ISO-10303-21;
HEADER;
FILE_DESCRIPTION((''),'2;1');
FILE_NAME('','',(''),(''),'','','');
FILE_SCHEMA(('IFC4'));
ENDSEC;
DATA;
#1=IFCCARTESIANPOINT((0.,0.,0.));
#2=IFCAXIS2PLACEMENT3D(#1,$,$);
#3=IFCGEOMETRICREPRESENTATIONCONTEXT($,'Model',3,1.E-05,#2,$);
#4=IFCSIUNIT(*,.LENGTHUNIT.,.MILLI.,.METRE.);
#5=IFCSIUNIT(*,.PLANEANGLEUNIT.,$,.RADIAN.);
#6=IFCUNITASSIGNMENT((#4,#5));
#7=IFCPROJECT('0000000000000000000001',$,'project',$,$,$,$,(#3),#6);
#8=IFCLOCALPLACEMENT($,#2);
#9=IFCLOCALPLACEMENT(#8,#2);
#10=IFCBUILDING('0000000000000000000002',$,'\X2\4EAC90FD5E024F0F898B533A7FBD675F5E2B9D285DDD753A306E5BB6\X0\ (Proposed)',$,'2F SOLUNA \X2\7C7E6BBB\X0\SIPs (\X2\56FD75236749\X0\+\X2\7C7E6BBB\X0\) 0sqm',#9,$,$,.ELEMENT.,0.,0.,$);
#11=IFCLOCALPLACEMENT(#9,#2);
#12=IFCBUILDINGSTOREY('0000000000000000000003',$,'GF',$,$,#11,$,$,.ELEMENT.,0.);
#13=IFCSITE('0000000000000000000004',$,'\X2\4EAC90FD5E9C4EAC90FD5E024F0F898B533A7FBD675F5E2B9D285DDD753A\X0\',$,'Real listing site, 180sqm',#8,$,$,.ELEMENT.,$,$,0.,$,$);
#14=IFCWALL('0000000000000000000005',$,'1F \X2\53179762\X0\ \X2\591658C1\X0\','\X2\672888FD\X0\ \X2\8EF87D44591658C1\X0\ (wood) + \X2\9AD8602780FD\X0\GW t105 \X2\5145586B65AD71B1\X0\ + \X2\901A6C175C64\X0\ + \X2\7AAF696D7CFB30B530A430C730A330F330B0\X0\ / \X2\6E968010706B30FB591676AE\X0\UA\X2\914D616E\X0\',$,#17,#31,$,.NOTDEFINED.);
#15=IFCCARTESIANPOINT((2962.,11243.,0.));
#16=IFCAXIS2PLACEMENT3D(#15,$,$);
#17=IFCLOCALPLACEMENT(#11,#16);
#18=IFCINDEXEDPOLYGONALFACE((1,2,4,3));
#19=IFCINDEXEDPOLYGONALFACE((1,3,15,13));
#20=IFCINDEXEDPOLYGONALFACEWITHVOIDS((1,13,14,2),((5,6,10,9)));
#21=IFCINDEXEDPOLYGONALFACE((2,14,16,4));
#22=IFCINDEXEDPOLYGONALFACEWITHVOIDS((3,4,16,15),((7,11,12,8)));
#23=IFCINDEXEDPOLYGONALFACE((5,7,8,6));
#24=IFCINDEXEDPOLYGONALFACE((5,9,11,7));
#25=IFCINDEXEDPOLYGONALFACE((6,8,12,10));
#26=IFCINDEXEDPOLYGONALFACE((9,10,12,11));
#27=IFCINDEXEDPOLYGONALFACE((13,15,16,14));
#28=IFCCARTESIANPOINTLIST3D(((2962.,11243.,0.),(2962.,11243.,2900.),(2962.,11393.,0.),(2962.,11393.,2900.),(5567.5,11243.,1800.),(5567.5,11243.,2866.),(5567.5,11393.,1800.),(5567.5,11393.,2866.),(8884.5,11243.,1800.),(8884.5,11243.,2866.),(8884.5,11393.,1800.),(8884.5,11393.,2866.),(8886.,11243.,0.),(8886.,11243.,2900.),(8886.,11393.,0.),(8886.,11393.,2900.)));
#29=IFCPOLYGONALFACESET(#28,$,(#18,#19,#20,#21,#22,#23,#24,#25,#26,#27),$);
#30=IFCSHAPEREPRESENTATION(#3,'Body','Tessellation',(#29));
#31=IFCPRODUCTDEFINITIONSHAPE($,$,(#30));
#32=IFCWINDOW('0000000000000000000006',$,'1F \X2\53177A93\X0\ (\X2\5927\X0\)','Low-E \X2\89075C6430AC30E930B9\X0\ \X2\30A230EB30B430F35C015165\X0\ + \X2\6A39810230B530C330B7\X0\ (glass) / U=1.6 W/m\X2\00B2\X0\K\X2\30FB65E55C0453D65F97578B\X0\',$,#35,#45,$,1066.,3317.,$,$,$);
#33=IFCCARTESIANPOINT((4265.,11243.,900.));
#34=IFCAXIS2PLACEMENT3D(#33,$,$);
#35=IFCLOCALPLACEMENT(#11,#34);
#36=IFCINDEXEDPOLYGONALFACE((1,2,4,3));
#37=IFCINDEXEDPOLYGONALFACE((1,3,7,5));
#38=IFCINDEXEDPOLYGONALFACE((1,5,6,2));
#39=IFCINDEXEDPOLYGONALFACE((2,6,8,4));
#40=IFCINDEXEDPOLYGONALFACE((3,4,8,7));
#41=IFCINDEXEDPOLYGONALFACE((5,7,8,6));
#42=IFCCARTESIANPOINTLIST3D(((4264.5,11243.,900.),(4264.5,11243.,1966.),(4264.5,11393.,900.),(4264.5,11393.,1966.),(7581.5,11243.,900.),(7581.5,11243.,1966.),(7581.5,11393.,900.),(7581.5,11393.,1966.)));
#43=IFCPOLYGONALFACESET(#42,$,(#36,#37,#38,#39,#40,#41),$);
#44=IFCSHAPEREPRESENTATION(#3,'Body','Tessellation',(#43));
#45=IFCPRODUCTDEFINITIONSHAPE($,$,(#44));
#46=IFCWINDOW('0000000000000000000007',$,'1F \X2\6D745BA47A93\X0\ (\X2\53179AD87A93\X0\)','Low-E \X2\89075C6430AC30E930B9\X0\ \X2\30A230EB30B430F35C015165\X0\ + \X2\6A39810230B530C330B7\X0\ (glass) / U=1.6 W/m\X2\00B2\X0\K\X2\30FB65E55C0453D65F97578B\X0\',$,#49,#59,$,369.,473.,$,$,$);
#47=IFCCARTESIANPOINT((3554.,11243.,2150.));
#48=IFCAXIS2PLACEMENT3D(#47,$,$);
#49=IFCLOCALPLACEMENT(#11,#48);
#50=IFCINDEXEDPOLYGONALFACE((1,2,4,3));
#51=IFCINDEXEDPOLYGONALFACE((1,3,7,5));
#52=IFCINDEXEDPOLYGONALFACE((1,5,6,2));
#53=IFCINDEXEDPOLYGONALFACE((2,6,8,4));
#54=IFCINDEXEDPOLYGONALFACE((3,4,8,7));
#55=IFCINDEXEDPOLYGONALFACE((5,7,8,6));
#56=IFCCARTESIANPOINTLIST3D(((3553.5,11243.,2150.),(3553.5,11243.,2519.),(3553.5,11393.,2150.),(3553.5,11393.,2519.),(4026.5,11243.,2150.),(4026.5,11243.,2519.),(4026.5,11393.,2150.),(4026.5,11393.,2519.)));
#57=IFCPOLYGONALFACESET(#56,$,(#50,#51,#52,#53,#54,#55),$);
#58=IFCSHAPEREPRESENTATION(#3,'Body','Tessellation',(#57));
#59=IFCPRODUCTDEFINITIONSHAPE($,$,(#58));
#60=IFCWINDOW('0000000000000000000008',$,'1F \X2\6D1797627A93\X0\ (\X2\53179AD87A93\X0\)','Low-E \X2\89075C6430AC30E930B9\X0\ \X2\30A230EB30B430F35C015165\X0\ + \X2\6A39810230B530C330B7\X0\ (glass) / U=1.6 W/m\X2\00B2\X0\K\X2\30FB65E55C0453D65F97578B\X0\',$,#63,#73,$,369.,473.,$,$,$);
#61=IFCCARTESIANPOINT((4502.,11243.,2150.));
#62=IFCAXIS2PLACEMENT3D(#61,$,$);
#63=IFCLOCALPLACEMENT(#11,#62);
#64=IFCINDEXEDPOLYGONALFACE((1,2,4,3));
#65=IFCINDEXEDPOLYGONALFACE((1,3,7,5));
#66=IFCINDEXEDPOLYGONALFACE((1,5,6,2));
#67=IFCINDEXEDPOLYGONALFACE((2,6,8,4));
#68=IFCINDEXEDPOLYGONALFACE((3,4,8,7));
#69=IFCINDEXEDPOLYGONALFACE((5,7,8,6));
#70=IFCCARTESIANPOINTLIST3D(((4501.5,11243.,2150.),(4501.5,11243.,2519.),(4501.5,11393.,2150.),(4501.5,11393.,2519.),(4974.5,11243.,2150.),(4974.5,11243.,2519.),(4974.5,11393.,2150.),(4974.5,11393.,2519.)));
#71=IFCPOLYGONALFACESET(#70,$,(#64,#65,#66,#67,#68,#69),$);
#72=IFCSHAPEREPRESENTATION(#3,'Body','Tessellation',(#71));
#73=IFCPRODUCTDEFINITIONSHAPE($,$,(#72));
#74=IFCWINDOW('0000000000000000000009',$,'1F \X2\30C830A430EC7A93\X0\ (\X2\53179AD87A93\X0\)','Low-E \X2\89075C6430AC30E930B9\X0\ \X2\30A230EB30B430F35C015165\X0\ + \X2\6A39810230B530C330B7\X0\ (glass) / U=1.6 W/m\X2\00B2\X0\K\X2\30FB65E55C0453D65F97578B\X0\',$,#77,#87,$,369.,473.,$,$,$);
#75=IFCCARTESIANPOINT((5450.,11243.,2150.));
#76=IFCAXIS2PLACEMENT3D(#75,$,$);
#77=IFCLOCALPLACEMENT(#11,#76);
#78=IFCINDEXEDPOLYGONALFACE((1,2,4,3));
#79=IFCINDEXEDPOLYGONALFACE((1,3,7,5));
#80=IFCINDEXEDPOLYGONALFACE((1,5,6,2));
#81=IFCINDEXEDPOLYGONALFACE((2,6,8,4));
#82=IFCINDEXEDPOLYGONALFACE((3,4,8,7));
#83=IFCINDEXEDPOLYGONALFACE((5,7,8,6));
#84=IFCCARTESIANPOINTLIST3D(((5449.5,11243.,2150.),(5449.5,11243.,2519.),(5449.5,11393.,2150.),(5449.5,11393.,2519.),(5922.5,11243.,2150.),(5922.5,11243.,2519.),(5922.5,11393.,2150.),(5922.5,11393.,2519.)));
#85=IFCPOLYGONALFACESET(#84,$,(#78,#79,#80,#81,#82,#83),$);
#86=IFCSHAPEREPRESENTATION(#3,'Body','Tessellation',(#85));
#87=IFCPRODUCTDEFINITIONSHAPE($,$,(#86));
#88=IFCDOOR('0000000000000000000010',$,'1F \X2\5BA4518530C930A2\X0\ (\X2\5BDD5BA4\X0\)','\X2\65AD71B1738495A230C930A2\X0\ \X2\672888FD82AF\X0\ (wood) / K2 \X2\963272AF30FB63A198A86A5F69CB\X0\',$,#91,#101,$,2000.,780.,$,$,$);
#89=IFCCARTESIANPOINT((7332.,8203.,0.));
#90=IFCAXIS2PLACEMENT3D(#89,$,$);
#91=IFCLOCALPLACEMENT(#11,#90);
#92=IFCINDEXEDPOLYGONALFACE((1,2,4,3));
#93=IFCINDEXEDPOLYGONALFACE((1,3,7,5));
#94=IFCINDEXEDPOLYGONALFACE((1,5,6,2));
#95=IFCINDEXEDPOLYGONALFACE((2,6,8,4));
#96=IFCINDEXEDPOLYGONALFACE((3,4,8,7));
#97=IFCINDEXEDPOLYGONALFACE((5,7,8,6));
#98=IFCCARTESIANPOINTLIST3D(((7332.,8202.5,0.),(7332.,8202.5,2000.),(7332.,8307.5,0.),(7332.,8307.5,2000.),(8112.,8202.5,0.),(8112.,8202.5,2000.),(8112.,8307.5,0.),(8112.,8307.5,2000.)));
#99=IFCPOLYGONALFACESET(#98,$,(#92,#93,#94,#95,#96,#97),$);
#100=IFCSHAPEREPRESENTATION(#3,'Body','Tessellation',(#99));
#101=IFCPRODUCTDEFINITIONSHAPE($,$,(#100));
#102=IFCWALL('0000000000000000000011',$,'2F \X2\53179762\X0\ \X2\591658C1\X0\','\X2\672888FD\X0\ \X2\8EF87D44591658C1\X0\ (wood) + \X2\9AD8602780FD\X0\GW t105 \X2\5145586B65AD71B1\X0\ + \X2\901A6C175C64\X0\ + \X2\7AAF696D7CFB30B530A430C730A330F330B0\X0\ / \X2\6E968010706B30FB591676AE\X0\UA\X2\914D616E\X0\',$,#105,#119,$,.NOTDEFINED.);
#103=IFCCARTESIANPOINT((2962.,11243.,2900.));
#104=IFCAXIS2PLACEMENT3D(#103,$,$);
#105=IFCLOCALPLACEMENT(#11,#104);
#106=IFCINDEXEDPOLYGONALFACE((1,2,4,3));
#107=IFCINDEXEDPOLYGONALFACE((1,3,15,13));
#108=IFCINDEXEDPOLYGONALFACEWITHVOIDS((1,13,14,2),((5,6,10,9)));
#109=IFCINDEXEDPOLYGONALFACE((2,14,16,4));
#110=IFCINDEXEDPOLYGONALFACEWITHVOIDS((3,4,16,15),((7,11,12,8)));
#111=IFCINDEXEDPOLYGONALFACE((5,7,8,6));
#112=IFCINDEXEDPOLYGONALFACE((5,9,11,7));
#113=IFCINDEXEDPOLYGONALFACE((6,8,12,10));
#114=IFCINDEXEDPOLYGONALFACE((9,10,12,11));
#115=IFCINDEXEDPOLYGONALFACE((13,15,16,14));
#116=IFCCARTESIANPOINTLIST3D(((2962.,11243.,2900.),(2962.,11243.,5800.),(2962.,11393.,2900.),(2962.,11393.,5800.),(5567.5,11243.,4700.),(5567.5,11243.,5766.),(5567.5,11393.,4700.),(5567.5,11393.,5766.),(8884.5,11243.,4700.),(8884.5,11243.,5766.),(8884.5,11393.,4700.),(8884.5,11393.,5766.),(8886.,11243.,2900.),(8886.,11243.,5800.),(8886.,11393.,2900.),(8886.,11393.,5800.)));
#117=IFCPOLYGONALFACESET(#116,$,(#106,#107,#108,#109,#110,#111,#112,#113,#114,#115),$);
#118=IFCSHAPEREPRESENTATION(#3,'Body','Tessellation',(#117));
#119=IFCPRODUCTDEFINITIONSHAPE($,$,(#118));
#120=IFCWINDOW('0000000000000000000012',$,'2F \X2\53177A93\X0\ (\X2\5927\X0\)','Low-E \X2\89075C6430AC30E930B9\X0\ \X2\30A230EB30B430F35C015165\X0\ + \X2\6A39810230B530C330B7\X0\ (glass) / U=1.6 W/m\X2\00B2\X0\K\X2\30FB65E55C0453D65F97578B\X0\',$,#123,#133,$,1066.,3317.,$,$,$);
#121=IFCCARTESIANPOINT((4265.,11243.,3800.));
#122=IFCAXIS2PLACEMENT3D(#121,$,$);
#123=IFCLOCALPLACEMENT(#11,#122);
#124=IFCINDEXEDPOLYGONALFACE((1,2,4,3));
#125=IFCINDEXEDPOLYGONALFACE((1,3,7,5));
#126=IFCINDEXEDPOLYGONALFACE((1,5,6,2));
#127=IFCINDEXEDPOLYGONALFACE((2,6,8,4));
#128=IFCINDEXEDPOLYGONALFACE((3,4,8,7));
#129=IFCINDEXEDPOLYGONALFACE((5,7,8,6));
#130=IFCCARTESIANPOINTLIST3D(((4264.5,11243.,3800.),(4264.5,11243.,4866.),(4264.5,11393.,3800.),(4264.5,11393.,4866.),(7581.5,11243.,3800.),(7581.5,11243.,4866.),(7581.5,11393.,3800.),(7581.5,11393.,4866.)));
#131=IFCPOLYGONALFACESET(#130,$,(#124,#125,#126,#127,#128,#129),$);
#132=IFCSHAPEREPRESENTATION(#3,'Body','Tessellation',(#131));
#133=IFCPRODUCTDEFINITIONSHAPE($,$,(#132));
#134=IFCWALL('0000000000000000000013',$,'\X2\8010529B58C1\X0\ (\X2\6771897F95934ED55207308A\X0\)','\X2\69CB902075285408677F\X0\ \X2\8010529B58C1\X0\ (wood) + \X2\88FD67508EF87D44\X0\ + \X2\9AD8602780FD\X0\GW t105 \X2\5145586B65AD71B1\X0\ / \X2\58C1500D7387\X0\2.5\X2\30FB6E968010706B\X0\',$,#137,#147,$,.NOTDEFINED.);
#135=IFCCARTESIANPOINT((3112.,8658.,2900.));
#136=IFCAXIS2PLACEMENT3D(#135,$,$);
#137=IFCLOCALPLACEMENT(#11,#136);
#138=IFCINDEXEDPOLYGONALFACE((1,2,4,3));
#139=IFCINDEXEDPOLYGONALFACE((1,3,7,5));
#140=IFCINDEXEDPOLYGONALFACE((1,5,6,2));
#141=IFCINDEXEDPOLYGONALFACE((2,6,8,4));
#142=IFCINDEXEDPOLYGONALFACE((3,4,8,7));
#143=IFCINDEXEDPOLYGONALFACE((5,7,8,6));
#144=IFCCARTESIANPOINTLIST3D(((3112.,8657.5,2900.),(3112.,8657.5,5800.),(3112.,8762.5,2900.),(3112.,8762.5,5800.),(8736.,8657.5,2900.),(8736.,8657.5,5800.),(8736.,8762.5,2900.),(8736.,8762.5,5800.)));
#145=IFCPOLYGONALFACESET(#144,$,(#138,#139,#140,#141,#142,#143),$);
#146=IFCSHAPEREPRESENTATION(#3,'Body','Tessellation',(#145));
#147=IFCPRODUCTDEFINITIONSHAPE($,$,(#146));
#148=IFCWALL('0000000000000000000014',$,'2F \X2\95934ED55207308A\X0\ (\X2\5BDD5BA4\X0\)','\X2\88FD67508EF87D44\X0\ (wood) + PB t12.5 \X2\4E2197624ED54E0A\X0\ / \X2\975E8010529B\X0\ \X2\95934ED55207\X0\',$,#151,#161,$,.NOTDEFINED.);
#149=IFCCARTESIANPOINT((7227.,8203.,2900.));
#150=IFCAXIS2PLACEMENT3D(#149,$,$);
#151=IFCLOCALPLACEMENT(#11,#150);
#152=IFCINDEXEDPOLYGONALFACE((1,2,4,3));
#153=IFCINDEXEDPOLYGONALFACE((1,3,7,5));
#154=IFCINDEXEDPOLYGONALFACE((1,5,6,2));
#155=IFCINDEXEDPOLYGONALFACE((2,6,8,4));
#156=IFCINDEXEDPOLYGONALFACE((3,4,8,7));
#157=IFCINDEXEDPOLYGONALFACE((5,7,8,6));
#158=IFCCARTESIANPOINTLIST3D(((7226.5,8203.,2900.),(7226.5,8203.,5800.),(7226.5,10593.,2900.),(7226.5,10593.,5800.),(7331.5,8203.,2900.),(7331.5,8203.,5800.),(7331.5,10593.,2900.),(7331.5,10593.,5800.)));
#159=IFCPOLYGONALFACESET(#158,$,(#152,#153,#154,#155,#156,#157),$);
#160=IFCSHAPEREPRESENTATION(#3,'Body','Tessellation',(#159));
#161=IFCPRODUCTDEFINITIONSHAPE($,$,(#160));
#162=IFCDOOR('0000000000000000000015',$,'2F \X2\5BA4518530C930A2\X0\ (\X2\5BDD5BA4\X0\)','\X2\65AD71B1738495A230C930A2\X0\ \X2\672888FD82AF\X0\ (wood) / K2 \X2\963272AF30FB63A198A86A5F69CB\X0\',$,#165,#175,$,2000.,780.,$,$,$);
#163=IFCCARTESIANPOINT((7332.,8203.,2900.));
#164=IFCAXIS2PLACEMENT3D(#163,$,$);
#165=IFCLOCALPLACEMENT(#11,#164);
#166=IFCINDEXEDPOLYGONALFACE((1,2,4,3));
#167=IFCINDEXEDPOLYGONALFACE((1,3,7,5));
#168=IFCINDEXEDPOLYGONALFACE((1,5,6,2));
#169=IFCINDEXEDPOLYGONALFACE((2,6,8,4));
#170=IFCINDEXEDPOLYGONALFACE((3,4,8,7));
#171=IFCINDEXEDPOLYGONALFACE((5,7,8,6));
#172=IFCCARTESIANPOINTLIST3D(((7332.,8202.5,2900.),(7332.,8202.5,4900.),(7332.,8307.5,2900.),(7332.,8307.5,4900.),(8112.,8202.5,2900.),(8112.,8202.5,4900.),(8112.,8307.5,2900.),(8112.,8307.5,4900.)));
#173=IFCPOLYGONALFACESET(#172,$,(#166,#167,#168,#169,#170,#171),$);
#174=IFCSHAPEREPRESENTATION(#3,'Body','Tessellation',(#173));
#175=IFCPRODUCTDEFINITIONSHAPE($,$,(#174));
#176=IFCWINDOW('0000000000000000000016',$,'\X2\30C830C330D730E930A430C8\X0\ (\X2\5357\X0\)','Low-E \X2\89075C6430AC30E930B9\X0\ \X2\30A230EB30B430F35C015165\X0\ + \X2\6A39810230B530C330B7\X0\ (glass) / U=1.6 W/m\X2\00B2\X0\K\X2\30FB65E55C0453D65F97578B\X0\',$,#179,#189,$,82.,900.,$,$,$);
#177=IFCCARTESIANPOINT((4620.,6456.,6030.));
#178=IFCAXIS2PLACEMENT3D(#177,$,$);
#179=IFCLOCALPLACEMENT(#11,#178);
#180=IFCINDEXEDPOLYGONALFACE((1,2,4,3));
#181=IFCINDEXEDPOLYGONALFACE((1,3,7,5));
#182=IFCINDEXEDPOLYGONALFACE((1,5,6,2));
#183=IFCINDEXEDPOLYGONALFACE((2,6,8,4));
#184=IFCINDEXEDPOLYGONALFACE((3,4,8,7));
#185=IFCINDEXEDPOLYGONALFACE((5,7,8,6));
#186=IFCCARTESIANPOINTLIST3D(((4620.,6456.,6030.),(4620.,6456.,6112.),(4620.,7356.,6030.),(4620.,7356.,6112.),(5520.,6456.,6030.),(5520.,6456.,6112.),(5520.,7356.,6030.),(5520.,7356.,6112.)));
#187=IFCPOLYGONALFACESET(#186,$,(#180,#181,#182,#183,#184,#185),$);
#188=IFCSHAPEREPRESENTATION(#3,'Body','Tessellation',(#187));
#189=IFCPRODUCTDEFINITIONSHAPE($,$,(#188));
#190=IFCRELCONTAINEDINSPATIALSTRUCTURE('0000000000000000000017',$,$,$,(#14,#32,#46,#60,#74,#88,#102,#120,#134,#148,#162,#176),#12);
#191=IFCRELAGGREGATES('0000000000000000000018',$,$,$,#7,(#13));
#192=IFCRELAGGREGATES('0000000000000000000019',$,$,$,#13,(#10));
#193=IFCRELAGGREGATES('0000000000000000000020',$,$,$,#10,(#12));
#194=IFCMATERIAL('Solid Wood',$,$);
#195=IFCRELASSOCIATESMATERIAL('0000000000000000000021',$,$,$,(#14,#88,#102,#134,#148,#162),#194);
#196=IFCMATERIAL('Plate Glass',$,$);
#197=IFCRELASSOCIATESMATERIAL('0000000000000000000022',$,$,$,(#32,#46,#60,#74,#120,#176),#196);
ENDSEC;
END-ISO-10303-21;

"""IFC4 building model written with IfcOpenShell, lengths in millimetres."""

from ifc_helpers import new_model, si_unit, frame, frame_2d, origin, place, context, project, spatial, rectangle, extrude, material, element, fill, save


model = new_model("IFC4")

# Units and contexts
model_context = context("Model", 3, precision=1e-05, world=origin())
ifc_project = project(units=[si_unit("LENGTHUNIT", "METRE", prefix="MILLI"), si_unit("PLANEANGLEUNIT", "RADIAN")], contexts=[model_context])

# Site, building, storey
site_placement = place(None, origin())
site = spatial("IfcSite", under=ifc_project, at=site_placement, Name="京都府京都市伏見区羽束師鴨川町", ObjectType="Real listing site, 180sqm", CompositionType="ELEMENT", RefElevation=0.0)
building_placement = place(site_placement, origin())
building = spatial("IfcBuilding", under=site, at=building_placement, Name="京都市伏見区羽束師鴨川町の家 (Proposed)", ObjectType="2F SOLUNA 籾殻SIPs (国産杉+籾殻) 0sqm", CompositionType="ELEMENT", ElevationOfRefHeight=0.0, ElevationOfTerrain=0.0)
storey_placement = place(building_placement, origin())
storey = spatial("IfcBuildingStorey", under=building, at=storey_placement, Name="GF", CompositionType="ELEMENT", Elevation=0.0)

# Wall, openings, windows
ifc_material_1 = material(Name="Solid Wood")
wall_1_placement = place(storey_placement, frame((2962.0, 11243.0, 0.0)))
wall_1 = element("IfcWall", 1, at=wall_1_placement, inside=storey, material=ifc_material_1, Name="1F 北面 外壁", Description="木製 軸組外壁 (wood) + 高性能GW t105 充填断熱 + 通気層 + 窯業系サイディング / 準耐火・外皮UA配慮", PredefinedType="NOTDEFINED", context=model_context, shape_type="SweptSolid", body=[
    extrude(rectangle(XDim=5924.0, YDim=150.0, at=frame_2d((2962.0, 75.0))), frame((2962.0, 11243.0, 0.0)), (0.0, 0.0, 1.0), 2900.0),
])
opening_1_placement = place(storey_placement, frame((4265.0, 11243.0, 900.0)))
opening_1 = element("IfcOpeningElement", 2, at=opening_1_placement, cuts=wall_1, PredefinedType="NOTDEFINED", context=model_context, shape_type="SweptSolid", body=[
    extrude(rectangle(XDim=3317.0, YDim=150.0, at=frame_2d((1658.0, 75.0))), frame((4265.0, 11243.0, 900.0)), (0.0, 0.0, 1.0), 1066.0),
])
opening_2_placement = place(storey_placement, frame((3554.0, 11243.0, 2150.0)))
opening_2 = element("IfcOpeningElement", 3, at=opening_2_placement, cuts=wall_1, PredefinedType="NOTDEFINED", context=model_context, shape_type="SweptSolid", body=[
    extrude(rectangle(XDim=473.0, YDim=150.0, at=frame_2d((236.0, 75.0))), frame((3554.0, 11243.0, 2150.0)), (0.0, 0.0, 1.0), 369.0),
])
opening_3_placement = place(storey_placement, frame((4502.0, 11243.0, 2150.0)))
opening_3 = element("IfcOpeningElement", 4, at=opening_3_placement, cuts=wall_1, PredefinedType="NOTDEFINED", context=model_context, shape_type="SweptSolid", body=[
    extrude(rectangle(XDim=473.0, YDim=150.0, at=frame_2d((236.0, 75.0))), frame((4502.0, 11243.0, 2150.0)), (0.0, 0.0, 1.0), 369.0),
])
opening_4_placement = place(storey_placement, frame((5450.0, 11243.0, 2150.0)))
opening_4 = element("IfcOpeningElement", 5, at=opening_4_placement, cuts=wall_1, PredefinedType="NOTDEFINED", context=model_context, shape_type="SweptSolid", body=[
    extrude(rectangle(XDim=473.0, YDim=150.0, at=frame_2d((236.0, 75.0))), frame((5450.0, 11243.0, 2150.0)), (0.0, 0.0, 1.0), 369.0),
])
ifc_material_2 = material(Name="Plate Glass")
window_1_placement = place(storey_placement, frame((4265.0, 11243.0, 900.0)))
window_1 = element("IfcWindow", 6, at=window_1_placement, inside=storey, material=ifc_material_2, Name="1F 北窓 (大)", Description="Low-E 複層ガラス アルゴン封入 + 樹脂サッシ (glass) / U=1.6 W/m²K・日射取得型", OverallHeight=1066.0, OverallWidth=3317.0, context=model_context, shape_type="SweptSolid", body=[
    extrude(rectangle(XDim=3317.0, YDim=150.0, at=frame_2d((1658.0, 75.0))), frame((4265.0, 11243.0, 900.0)), (0.0, 0.0, 1.0), 1066.0),
])
fill(opening_1, window_1)
window_2_placement = place(storey_placement, frame((3554.0, 11243.0, 2150.0)))
window_2 = element("IfcWindow", 7, at=window_2_placement, inside=storey, material=ifc_material_2, Name="1F 浴室窓 (北高窓)", Description="Low-E 複層ガラス アルゴン封入 + 樹脂サッシ (glass) / U=1.6 W/m²K・日射取得型", OverallHeight=369.0, OverallWidth=473.0, context=model_context, shape_type="SweptSolid", body=[
    extrude(rectangle(XDim=473.0, YDim=150.0, at=frame_2d((236.0, 75.0))), frame((3554.0, 11243.0, 2150.0)), (0.0, 0.0, 1.0), 369.0),
])
fill(opening_2, window_2)
window_3_placement = place(storey_placement, frame((4502.0, 11243.0, 2150.0)))
window_3 = element("IfcWindow", 8, at=window_3_placement, inside=storey, material=ifc_material_2, Name="1F 洗面窓 (北高窓)", Description="Low-E 複層ガラス アルゴン封入 + 樹脂サッシ (glass) / U=1.6 W/m²K・日射取得型", OverallHeight=369.0, OverallWidth=473.0, context=model_context, shape_type="SweptSolid", body=[
    extrude(rectangle(XDim=473.0, YDim=150.0, at=frame_2d((236.0, 75.0))), frame((4502.0, 11243.0, 2150.0)), (0.0, 0.0, 1.0), 369.0),
])
fill(opening_3, window_3)
window_4_placement = place(storey_placement, frame((5450.0, 11243.0, 2150.0)))
window_4 = element("IfcWindow", 9, at=window_4_placement, inside=storey, material=ifc_material_2, Name="1F トイレ窓 (北高窓)", Description="Low-E 複層ガラス アルゴン封入 + 樹脂サッシ (glass) / U=1.6 W/m²K・日射取得型", OverallHeight=369.0, OverallWidth=473.0, context=model_context, shape_type="SweptSolid", body=[
    extrude(rectangle(XDim=473.0, YDim=150.0, at=frame_2d((236.0, 75.0))), frame((5450.0, 11243.0, 2150.0)), (0.0, 0.0, 1.0), 369.0),
])
fill(opening_4, window_4)

# Door
door_1_placement = place(storey_placement, frame((7332.0, 8203.0, 0.0)))
element("IfcDoor", 10, at=door_1_placement, inside=storey, material=ifc_material_1, Name="1F 室内ドア (寝室)", Description="断熱玄関ドア 木製芯 (wood) / K2 防犯・採風機構", OverallHeight=2000.0, OverallWidth=780.0, context=model_context, shape_type="SweptSolid", body=[
    extrude(rectangle(XDim=780.0, YDim=105.0, at=frame_2d((390.0, 52.0))), frame((7332.0, 8203.0, 0.0)), (0.0, 0.0, 1.0), 2000.0),
])

# Wall, opening, window
wall_2_placement = place(storey_placement, frame((2962.0, 11243.0, 2900.0)))
wall_2 = element("IfcWall", 11, at=wall_2_placement, inside=storey, material=ifc_material_1, Name="2F 北面 外壁", Description="木製 軸組外壁 (wood) + 高性能GW t105 充填断熱 + 通気層 + 窯業系サイディング / 準耐火・外皮UA配慮", PredefinedType="NOTDEFINED", context=model_context, shape_type="SweptSolid", body=[
    extrude(rectangle(XDim=5924.0, YDim=150.0, at=frame_2d((2962.0, 75.0))), frame((2962.0, 11243.0, 2900.0)), (0.0, 0.0, 1.0), 2900.0),
])
opening_5_placement = place(storey_placement, frame((4265.0, 11243.0, 3800.0)))
opening_5 = element("IfcOpeningElement", 12, at=opening_5_placement, cuts=wall_2, PredefinedType="NOTDEFINED", context=model_context, shape_type="SweptSolid", body=[
    extrude(rectangle(XDim=3317.0, YDim=150.0, at=frame_2d((1658.0, 75.0))), frame((4265.0, 11243.0, 3800.0)), (0.0, 0.0, 1.0), 1066.0),
])
window_5_placement = place(storey_placement, frame((4265.0, 11243.0, 3800.0)))
window_5 = element("IfcWindow", 13, at=window_5_placement, inside=storey, material=ifc_material_2, Name="2F 北窓 (大)", Description="Low-E 複層ガラス アルゴン封入 + 樹脂サッシ (glass) / U=1.6 W/m²K・日射取得型", OverallHeight=1066.0, OverallWidth=3317.0, context=model_context, shape_type="SweptSolid", body=[
    extrude(rectangle(XDim=3317.0, YDim=150.0, at=frame_2d((1658.0, 75.0))), frame((4265.0, 11243.0, 3800.0)), (0.0, 0.0, 1.0), 1066.0),
])
fill(opening_5, window_5)

# Walls
wall_3_placement = place(storey_placement, frame((3112.0, 8658.0, 2900.0)))
element("IfcWall", 14, at=wall_3_placement, inside=storey, material=ifc_material_1, Name="耐力壁 (東西間仕切り)", Description="構造用合板 耐力壁 (wood) + 製材軸組 + 高性能GW t105 充填断熱 / 壁倍率2.5・準耐火", PredefinedType="NOTDEFINED", context=model_context, shape_type="SweptSolid", body=[
    extrude(rectangle(XDim=5624.0, YDim=105.0, at=frame_2d((2812.0, 52.0))), frame((3112.0, 8658.0, 2900.0)), (0.0, 0.0, 1.0), 2900.0),
])
wall_4_placement = place(storey_placement, frame((7227.0, 8203.0, 2900.0)))
element("IfcWall", 15, at=wall_4_placement, inside=storey, material=ifc_material_1, Name="2F 間仕切り (寝室)", Description="製材軸組 (wood) + PB t12.5 両面仕上 / 非耐力 間仕切", PredefinedType="NOTDEFINED", context=model_context, shape_type="SweptSolid", body=[
    extrude(rectangle(XDim=105.0, YDim=2390.0, at=frame_2d((52.0, 1195.0))), frame((7227.0, 8203.0, 2900.0)), (0.0, 0.0, 1.0), 2900.0),
])

# Door
door_2_placement = place(storey_placement, frame((7332.0, 8203.0, 2900.0)))
element("IfcDoor", 16, at=door_2_placement, inside=storey, material=ifc_material_1, Name="2F 室内ドア (寝室)", Description="断熱玄関ドア 木製芯 (wood) / K2 防犯・採風機構", OverallHeight=2000.0, OverallWidth=780.0, context=model_context, shape_type="SweptSolid", body=[
    extrude(rectangle(XDim=780.0, YDim=105.0, at=frame_2d((390.0, 52.0))), frame((7332.0, 8203.0, 2900.0)), (0.0, 0.0, 1.0), 2000.0),
])

# Window
window_6_placement = place(storey_placement, frame((4620.0, 6456.0, 6030.0)))
element("IfcWindow", 17, at=window_6_placement, inside=storey, material=ifc_material_2, Name="トップライト (南)", Description="Low-E 複層ガラス アルゴン封入 + 樹脂サッシ (glass) / U=1.6 W/m²K・日射取得型", OverallHeight=82.0, OverallWidth=900.0, context=model_context, shape_type="SweptSolid", body=[
    extrude(rectangle(XDim=900.0, YDim=900.0, at=frame_2d((450.0, 450.0))), frame((4620.0, 6456.0, 6030.0)), (0.0, 0.0, 1.0), 82.0),
])

save(model, "model.ifc")
